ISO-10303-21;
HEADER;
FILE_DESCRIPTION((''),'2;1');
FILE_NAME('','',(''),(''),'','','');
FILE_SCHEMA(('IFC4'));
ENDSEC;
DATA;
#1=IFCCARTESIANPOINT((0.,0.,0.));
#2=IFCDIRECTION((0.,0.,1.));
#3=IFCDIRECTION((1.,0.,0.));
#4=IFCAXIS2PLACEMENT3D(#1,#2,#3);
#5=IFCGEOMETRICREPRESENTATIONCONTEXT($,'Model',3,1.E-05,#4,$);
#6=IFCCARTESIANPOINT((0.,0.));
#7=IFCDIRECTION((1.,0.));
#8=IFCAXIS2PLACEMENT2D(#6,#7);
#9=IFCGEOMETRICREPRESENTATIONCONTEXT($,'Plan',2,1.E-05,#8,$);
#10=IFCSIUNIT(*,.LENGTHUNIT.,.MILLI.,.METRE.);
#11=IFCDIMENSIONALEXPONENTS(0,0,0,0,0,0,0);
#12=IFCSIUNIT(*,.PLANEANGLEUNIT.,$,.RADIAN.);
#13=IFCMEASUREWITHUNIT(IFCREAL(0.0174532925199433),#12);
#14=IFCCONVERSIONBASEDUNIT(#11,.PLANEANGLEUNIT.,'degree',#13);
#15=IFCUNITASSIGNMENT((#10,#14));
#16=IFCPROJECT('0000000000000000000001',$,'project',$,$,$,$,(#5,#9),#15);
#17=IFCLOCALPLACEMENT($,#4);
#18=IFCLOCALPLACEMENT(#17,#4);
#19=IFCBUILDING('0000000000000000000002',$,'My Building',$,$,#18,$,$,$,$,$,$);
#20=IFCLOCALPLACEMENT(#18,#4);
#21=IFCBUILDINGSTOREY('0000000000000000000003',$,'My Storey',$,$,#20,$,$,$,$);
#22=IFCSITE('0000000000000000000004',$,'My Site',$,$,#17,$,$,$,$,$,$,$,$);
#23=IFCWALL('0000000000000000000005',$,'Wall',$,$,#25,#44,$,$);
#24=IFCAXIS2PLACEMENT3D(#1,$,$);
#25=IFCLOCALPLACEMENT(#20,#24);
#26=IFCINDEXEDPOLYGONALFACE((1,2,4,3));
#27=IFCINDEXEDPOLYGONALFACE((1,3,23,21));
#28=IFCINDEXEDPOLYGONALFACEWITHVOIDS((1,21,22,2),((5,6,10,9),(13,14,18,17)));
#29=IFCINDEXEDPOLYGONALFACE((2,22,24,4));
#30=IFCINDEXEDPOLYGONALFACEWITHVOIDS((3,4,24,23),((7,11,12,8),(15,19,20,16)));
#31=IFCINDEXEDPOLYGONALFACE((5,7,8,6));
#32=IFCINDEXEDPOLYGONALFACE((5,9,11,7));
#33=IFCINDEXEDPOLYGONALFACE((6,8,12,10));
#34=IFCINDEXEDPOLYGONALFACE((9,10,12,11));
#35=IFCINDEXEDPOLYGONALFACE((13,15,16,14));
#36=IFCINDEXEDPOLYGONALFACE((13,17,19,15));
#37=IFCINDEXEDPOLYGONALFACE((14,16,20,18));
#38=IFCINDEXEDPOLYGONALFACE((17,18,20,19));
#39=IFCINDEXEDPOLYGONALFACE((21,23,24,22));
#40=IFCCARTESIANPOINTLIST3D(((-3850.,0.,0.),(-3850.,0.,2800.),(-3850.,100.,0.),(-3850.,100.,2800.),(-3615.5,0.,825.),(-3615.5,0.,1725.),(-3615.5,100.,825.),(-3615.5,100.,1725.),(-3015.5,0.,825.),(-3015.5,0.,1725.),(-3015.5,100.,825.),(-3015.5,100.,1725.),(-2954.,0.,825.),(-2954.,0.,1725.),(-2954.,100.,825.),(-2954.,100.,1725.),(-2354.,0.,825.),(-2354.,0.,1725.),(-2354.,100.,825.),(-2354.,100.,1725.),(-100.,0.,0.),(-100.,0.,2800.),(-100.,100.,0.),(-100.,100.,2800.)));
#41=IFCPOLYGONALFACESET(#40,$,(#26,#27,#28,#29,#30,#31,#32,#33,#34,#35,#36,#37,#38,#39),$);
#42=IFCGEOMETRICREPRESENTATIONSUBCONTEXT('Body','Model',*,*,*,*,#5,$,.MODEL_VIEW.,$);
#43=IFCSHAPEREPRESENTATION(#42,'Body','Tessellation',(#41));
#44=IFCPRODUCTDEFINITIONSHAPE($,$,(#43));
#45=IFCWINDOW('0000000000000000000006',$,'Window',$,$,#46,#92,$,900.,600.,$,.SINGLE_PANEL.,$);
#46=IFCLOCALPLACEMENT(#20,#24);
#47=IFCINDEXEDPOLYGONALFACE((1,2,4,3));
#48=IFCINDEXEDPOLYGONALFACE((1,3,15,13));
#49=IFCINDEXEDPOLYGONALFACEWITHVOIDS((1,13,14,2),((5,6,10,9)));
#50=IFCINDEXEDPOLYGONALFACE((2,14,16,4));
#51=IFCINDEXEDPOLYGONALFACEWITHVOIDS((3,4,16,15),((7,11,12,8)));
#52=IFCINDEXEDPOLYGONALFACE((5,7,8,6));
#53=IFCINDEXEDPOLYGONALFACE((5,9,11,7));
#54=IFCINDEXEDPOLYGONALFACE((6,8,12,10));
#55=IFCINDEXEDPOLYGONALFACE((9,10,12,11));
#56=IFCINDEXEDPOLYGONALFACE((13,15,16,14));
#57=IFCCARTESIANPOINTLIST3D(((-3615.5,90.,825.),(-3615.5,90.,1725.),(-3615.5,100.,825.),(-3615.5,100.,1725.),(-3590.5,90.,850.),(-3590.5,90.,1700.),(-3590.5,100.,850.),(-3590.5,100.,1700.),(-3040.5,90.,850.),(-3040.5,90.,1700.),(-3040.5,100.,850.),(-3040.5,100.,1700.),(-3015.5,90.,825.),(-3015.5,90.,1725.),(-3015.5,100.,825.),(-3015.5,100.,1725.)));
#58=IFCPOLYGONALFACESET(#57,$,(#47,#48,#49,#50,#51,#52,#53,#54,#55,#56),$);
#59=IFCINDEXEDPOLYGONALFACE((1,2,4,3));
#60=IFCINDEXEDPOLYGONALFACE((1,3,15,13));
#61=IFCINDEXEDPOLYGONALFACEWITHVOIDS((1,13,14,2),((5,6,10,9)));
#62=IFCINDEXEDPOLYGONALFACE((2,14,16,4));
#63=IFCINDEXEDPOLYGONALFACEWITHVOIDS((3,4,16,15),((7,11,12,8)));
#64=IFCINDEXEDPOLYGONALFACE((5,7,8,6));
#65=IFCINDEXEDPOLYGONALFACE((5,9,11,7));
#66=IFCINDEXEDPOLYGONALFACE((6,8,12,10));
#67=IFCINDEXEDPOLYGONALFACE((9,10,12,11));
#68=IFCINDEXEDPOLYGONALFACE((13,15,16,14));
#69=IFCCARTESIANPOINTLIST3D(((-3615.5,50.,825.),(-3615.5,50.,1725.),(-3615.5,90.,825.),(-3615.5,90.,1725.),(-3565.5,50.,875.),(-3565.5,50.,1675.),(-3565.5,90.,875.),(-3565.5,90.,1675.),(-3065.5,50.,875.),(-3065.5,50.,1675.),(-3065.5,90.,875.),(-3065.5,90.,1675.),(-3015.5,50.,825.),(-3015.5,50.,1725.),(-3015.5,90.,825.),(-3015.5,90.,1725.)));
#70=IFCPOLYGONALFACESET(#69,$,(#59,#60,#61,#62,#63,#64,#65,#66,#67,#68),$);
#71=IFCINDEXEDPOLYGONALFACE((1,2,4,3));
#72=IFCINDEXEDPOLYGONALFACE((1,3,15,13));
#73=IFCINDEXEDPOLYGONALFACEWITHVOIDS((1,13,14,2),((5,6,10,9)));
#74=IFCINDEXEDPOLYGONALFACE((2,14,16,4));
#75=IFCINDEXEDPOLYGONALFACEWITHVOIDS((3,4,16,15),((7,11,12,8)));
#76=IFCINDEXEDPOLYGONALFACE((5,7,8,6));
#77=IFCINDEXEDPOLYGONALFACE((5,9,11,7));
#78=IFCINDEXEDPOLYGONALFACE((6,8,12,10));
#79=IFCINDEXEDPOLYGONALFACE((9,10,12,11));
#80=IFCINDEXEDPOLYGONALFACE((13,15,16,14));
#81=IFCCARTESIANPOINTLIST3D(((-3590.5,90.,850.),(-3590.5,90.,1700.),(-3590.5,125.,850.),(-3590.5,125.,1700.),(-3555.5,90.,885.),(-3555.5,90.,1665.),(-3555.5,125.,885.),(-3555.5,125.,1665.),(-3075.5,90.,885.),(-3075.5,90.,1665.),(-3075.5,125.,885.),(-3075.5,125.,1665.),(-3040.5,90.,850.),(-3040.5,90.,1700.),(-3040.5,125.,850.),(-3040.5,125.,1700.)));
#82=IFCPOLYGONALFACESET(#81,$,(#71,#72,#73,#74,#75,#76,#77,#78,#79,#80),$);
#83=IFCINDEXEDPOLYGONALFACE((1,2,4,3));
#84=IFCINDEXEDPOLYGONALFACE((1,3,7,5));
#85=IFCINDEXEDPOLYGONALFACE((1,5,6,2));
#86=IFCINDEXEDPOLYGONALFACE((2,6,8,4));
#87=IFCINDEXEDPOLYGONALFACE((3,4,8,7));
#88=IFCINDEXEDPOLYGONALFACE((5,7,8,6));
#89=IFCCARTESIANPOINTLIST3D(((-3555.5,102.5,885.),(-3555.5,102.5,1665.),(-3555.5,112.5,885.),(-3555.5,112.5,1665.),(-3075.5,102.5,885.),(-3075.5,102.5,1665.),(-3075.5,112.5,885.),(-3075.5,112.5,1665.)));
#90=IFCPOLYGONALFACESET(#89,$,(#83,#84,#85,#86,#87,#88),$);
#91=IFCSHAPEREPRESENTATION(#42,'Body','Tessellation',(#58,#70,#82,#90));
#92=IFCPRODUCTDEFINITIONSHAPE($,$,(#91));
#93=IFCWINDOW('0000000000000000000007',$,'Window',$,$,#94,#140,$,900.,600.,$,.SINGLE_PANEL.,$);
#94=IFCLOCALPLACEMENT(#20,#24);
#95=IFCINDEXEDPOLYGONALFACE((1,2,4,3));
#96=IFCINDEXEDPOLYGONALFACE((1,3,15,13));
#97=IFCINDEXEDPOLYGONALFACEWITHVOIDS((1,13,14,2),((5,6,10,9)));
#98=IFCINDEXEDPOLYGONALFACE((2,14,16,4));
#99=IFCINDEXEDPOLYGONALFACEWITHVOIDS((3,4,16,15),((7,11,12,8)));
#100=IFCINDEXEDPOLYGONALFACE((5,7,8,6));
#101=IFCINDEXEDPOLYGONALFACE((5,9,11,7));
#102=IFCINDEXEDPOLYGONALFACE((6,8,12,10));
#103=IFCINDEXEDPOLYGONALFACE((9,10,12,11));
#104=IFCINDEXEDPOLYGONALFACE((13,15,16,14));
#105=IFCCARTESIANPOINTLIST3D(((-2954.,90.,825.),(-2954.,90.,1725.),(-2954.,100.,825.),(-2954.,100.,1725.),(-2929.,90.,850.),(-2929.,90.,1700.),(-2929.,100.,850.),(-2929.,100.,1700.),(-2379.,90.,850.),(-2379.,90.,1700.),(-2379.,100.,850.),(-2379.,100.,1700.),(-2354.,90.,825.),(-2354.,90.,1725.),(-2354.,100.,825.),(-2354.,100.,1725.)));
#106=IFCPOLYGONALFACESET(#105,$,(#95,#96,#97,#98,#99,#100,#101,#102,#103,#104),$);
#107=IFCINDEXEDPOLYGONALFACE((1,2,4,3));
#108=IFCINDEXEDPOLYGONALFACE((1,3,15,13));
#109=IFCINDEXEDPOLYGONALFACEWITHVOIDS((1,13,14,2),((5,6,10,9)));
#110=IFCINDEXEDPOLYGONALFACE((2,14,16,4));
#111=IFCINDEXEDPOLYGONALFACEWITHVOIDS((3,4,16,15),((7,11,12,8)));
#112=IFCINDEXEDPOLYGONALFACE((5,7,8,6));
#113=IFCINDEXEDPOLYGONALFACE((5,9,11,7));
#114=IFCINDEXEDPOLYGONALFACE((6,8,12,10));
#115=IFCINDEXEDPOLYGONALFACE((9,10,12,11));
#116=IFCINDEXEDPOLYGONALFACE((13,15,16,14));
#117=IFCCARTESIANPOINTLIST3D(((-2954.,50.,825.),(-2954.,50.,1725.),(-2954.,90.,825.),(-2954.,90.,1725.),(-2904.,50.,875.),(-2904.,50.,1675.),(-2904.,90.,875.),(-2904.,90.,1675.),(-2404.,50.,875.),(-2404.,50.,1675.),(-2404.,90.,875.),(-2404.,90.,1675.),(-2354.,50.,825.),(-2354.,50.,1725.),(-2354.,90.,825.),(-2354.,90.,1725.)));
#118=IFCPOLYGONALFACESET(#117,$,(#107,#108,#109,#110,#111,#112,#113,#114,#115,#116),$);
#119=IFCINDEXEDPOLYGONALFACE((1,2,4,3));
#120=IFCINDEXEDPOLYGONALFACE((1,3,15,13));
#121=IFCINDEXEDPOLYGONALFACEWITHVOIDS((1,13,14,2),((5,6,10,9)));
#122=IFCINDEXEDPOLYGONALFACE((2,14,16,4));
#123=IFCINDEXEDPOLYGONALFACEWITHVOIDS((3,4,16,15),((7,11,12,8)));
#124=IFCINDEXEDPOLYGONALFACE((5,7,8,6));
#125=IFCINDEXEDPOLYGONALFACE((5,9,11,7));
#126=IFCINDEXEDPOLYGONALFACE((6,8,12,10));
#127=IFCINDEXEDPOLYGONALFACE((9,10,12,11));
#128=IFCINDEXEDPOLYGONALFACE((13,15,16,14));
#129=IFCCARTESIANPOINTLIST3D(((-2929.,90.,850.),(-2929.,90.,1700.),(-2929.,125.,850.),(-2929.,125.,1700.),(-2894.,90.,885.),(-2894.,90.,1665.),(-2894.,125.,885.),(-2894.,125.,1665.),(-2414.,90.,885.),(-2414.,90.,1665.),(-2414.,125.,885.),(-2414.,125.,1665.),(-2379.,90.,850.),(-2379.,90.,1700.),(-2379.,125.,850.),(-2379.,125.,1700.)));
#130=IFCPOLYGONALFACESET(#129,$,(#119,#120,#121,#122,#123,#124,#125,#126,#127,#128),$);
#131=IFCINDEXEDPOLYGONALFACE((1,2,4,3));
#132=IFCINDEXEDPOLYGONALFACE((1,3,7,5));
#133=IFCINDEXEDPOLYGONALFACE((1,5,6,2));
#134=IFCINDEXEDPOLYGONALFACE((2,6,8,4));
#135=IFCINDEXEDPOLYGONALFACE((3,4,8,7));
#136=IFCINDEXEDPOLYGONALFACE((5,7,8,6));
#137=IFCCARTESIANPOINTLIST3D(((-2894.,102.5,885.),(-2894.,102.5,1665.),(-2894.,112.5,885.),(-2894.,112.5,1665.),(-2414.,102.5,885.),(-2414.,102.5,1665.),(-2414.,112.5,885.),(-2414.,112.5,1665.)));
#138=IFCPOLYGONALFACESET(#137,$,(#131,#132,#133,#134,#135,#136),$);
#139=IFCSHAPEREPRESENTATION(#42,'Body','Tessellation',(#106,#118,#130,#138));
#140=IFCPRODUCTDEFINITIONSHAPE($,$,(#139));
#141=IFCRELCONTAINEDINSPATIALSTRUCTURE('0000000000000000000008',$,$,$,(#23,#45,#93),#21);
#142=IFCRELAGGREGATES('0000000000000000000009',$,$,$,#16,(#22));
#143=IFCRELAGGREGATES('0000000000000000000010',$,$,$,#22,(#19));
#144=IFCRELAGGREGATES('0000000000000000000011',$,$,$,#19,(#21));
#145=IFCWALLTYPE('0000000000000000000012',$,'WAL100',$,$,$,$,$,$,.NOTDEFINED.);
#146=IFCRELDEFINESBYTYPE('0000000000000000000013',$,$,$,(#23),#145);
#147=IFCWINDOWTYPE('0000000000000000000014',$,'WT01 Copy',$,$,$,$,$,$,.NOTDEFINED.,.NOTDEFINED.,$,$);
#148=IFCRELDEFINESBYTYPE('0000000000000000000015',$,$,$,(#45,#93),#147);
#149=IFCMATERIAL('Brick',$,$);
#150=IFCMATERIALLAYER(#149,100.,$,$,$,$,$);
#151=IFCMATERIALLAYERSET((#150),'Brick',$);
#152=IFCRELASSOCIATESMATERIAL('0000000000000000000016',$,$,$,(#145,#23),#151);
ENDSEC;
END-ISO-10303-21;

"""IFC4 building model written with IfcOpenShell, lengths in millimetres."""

from ifc_helpers import new_model, entity, si_unit, converted_unit, frame, origin_with_axes, origin_2d_with_axis, place, context, subcontext, project, spatial, line, indexed_curve, outline, extrude, shape, source, transform, mapped, material, layer, layer_set, layer_usage, type_object, type_shapes, element, fill, save


model = new_model("IFC4")

# Units and contexts
model_context = context("Model", 3, precision=1e-05, world=origin_with_axes())
plan_context = context("Plan", 2, precision=1e-05, world=origin_2d_with_axis())
body_context_1 = subcontext(model_context, "Body", "Model", "MODEL_VIEW")
body_context_2 = subcontext(plan_context, "Body", "Plan", "PLAN_VIEW")
ifc_project = project(units=[si_unit("LENGTHUNIT", "METRE", prefix="MILLI"), converted_unit("PLANEANGLEUNIT", "degree", entity("IfcReal", 0.0174532925199433), si_unit("PLANEANGLEUNIT", "RADIAN"), dimensions=[0, 0, 0, 0, 0, 0, 0])], contexts=[model_context, plan_context])

# Site, building, storey
site_placement = place(None, origin_with_axes())
site = spatial("IfcSite", under=ifc_project, at=site_placement, Name="My Site")
building_placement = place(site_placement, origin_with_axes())
building = spatial("IfcBuilding", under=site, at=building_placement, Name="My Building")
storey_placement = place(building_placement, origin_with_axes())
storey = spatial("IfcBuildingStorey", under=building, at=storey_placement, Name="My Storey")

# Shared definitions
ifc_material = material(Name="Brick")
ifc_layer_1 = layer(ifc_material, 100.0)
ifc_layer_set_1 = layer_set([ifc_layer_1], Name="Brick")
wall_type = type_object("IfcWallType", Name="WAL100", PredefinedType="NOTDEFINED", material=ifc_layer_set_1)
shared_shape_1 = source(origin_with_axes(), body_context_1, "Body", "SweptSolid", [
    extrude(outline(indexed_curve([(0.0, 0.0), (600.0, 0.0), (600.0, 900.0), (0.0, 900.0)], segments=[line(1, 2, 3, 4, 1)])), frame((0.0, -100.0, 0.0), z_axis=(0.0, -1.0, 0.0), x_axis=(1.0, 0.0, 0.0)), (0.0, 0.0, -1.0), 300.0),
])
window_type_1 = type_object("IfcWindowType", Name="WT01 Copy", PartitioningType="NOTDEFINED", PredefinedType="NOTDEFINED")
shared_shape_2 = source(origin_with_axes(), body_context_1, "Body", "SweptSolid", [
    extrude(outline(indexed_curve([(0.0, 0.0), (600.0, 0.0), (600.0, 900.0), (0.0, 900.0)], segments=[line(1, 2, 3, 4, 1)]), holes=[indexed_curve([(25.0, 25.0), (575.0, 25.0), (575.0, 875.0), (25.0, 875.0)], segments=[line(1, 2, 3, 4, 1)])]), frame((0.0, 90.0, 0.0), z_axis=(0.0, -1.0, 0.0), x_axis=(1.0, 0.0, 0.0)), (0.0, 0.0, -1.0), 10.0),
    extrude(outline(indexed_curve([(0.0, 0.0), (600.0, 0.0), (600.0, 900.0), (0.0, 900.0)], segments=[line(1, 2, 3, 4, 1)]), holes=[indexed_curve([(50.0, 50.0), (550.0, 50.0), (550.0, 850.0), (50.0, 850.0)], segments=[line(1, 2, 3, 4, 1)])]), frame((0.0, 50.0, 0.0), z_axis=(0.0, -1.0, 0.0), x_axis=(1.0, 0.0, 0.0)), (0.0, 0.0, -1.0), 40.0),
    extrude(outline(indexed_curve([(0.0, 0.0), (550.0, 0.0), (550.0, 850.0), (0.0, 850.0)], segments=[line(1, 2, 3, 4, 1)]), holes=[indexed_curve([(35.0, 35.0), (515.0, 35.0), (515.0, 815.0), (35.0, 815.0)], segments=[line(1, 2, 3, 4, 1)])]), frame((25.0, 90.0, 25.0), z_axis=(0.0, -1.0, 0.0), x_axis=(1.0, 0.0, 0.0)), (0.0, 0.0, -1.0), 35.0),
    extrude(outline(indexed_curve([(35.0, 35.0), (515.0, 35.0), (515.0, 815.0), (35.0, 815.0)], segments=[line(1, 2, 3, 4, 1)])), frame((25.0, 102.5, 25.0), z_axis=(0.0, -1.0, 0.0), x_axis=(1.0, 0.0, 0.0)), (0.0, 0.0, -1.0), 10.0),
])
shared_shape_3 = source(origin_with_axes(), body_context_2, "Body", "Curve2D", [
    entity("IfcIndexedPolyCurve", entity("IfcCartesianPointList2D", [[50.0, 50.0], [550.0, 50.0]])),
    entity("IfcIndexedPolyCurve", entity("IfcCartesianPointList2D", [[0.0, 100.0], [25.0, 100.0], [25.0, 90.0], [50.0, 90.0], [50.0, 50.0], [0.0, 50.0]]), [entity("IfcLineIndex", [1, 2, 3, 4, 5, 6, 1])]),
    entity("IfcIndexedPolyCurve", entity("IfcCartesianPointList2D", [[600.0, 100.0], [575.0, 100.0], [575.0, 90.0], [550.0, 90.0], [550.0, 50.0], [600.0, 50.0]]), [entity("IfcLineIndex", [1, 2, 3, 4, 5, 6, 1])]),
    entity("IfcIndexedPolyCurve", entity("IfcCartesianPointList2D", [[25.0, 90.0], [60.0, 90.0], [60.0, 125.0], [25.0, 125.0]]), [entity("IfcLineIndex", [1, 2, 3, 4, 1])]),
    entity("IfcIndexedPolyCurve", entity("IfcCartesianPointList2D", [[575.0, 90.0], [540.0, 90.0], [540.0, 125.0], [575.0, 125.0]]), [entity("IfcLineIndex", [1, 2, 3, 4, 1])]),
    entity("IfcIndexedPolyCurve", entity("IfcCartesianPointList2D", [[60.0, 90.0], [540.0, 90.0]])),
    entity("IfcIndexedPolyCurve", entity("IfcCartesianPointList2D", [[60.0, 125.0], [540.0, 125.0]])),
    entity("IfcIndexedPolyCurve", entity("IfcCartesianPointList2D", [[60.0, 107.5], [540.0, 107.5]])),
])
type_shapes(window_type_1, [shared_shape_2, shared_shape_3])

# Wall, openings, windows
ifc_layer_usage_1 = layer_usage(ifc_layer_set_1, "AXIS2", "POSITIVE", 0.0)
wall_1_placement = place(storey_placement, frame((-100.0, 100.0, 0.0), z_axis=(0.0, 0.0, 1.0), x_axis=(-1.0, 0.0, 0.0)))
wall_1 = element("IfcWall", 1, at=wall_1_placement, inside=storey, type_object=wall_type, material=ifc_layer_usage_1, Name="Wall", context=body_context_1, shape_type="SweptSolid", body=[
    extrude(outline(indexed_curve([(0.0, 0.0), (0.0, 100.0), (3750.0, 100.0), (3750.0, 0.0), (0.0, 0.0)], self_intersect=False)), origin_with_axes(), (0.0, 0.0, 1.0), 2800.0),
])
opening_1_placement = place(wall_1_placement, frame((2915.5, 0.0, 825.0), z_axis=(0.0, 0.0, 1.0), x_axis=(1.0, 0.0, 0.0)))
opening_1 = element("IfcOpeningElement", 2, at=opening_1_placement, cuts=wall_1, PredefinedType="OPENING", context=body_context_1, shape_type="MappedRepresentation", body=[
    mapped(shared_shape_1, transform((0.0, 0.0, 0.0), x_axis=(1.0, 0.0, 0.0), y_axis=(0.0, 1.0, 0.0), z_axis=(0.0, 0.0, 1.0), scale=1.0)),
])
opening_2_placement = place(wall_1_placement, frame((2854.0, 100.0, 825.0), z_axis=(0.0, 0.0, 1.0), x_axis=(-1.0, 0.0, 0.0)))
opening_2 = element("IfcOpeningElement", 3, at=opening_2_placement, cuts=wall_1, PredefinedType="OPENING", context=body_context_1, shape_type="MappedRepresentation", body=[
    mapped(shared_shape_1, transform((0.0, 0.0, 0.0), x_axis=(1.0, 0.0, 0.0), y_axis=(0.0, 1.0, 0.0), z_axis=(0.0, 0.0, 1.0), scale=1.0)),
])
window_1_placement = place(opening_1_placement, frame((600.0, 100.0, 0.0), z_axis=(0.0, 0.0, 1.0), x_axis=(-1.0, 0.0, 0.0)))
window_1 = element("IfcWindow", 4, at=window_1_placement, inside=storey, type_object=window_type_1, Name="Window", OverallHeight=900.0, OverallWidth=600.0, PartitioningType="SINGLE_PANEL", shapes=[
    shape(body_context_1, "Body", "MappedRepresentation", [mapped(shared_shape_2, transform((0.0, 0.0, 0.0), x_axis=(1.0, 0.0, 0.0), y_axis=(0.0, 1.0, 0.0), z_axis=(0.0, 0.0, 1.0), scale=1.0))]),
    shape(body_context_2, "Body", "MappedRepresentation", [mapped(shared_shape_3, transform((0.0, 0.0, 0.0), x_axis=(1.0, 0.0, 0.0), y_axis=(0.0, 1.0, 0.0), z_axis=(0.0, 0.0, 1.0), scale=1.0))]),
])
fill(opening_1, window_1)
window_2_placement = place(opening_2_placement, frame((0.0, 0.0, 0.0), z_axis=(0.0, 0.0, 1.0), x_axis=(1.0, 0.0, 0.0)))
window_2 = element("IfcWindow", 5, at=window_2_placement, inside=storey, type_object=window_type_1, Name="Window", OverallHeight=900.0, OverallWidth=600.0, PartitioningType="SINGLE_PANEL", shapes=[
    shape(body_context_1, "Body", "MappedRepresentation", [mapped(shared_shape_2, transform((0.0, 0.0, 0.0), x_axis=(1.0, 0.0, 0.0), y_axis=(0.0, 1.0, 0.0), z_axis=(0.0, 0.0, 1.0), scale=1.0))]),
    shape(body_context_2, "Body", "MappedRepresentation", [mapped(shared_shape_3, transform((0.0, 0.0, 0.0), x_axis=(1.0, 0.0, 0.0), y_axis=(0.0, 1.0, 0.0), z_axis=(0.0, 0.0, 1.0), scale=1.0))]),
])
fill(opening_2, window_2)

save(model, "model.ifc")
